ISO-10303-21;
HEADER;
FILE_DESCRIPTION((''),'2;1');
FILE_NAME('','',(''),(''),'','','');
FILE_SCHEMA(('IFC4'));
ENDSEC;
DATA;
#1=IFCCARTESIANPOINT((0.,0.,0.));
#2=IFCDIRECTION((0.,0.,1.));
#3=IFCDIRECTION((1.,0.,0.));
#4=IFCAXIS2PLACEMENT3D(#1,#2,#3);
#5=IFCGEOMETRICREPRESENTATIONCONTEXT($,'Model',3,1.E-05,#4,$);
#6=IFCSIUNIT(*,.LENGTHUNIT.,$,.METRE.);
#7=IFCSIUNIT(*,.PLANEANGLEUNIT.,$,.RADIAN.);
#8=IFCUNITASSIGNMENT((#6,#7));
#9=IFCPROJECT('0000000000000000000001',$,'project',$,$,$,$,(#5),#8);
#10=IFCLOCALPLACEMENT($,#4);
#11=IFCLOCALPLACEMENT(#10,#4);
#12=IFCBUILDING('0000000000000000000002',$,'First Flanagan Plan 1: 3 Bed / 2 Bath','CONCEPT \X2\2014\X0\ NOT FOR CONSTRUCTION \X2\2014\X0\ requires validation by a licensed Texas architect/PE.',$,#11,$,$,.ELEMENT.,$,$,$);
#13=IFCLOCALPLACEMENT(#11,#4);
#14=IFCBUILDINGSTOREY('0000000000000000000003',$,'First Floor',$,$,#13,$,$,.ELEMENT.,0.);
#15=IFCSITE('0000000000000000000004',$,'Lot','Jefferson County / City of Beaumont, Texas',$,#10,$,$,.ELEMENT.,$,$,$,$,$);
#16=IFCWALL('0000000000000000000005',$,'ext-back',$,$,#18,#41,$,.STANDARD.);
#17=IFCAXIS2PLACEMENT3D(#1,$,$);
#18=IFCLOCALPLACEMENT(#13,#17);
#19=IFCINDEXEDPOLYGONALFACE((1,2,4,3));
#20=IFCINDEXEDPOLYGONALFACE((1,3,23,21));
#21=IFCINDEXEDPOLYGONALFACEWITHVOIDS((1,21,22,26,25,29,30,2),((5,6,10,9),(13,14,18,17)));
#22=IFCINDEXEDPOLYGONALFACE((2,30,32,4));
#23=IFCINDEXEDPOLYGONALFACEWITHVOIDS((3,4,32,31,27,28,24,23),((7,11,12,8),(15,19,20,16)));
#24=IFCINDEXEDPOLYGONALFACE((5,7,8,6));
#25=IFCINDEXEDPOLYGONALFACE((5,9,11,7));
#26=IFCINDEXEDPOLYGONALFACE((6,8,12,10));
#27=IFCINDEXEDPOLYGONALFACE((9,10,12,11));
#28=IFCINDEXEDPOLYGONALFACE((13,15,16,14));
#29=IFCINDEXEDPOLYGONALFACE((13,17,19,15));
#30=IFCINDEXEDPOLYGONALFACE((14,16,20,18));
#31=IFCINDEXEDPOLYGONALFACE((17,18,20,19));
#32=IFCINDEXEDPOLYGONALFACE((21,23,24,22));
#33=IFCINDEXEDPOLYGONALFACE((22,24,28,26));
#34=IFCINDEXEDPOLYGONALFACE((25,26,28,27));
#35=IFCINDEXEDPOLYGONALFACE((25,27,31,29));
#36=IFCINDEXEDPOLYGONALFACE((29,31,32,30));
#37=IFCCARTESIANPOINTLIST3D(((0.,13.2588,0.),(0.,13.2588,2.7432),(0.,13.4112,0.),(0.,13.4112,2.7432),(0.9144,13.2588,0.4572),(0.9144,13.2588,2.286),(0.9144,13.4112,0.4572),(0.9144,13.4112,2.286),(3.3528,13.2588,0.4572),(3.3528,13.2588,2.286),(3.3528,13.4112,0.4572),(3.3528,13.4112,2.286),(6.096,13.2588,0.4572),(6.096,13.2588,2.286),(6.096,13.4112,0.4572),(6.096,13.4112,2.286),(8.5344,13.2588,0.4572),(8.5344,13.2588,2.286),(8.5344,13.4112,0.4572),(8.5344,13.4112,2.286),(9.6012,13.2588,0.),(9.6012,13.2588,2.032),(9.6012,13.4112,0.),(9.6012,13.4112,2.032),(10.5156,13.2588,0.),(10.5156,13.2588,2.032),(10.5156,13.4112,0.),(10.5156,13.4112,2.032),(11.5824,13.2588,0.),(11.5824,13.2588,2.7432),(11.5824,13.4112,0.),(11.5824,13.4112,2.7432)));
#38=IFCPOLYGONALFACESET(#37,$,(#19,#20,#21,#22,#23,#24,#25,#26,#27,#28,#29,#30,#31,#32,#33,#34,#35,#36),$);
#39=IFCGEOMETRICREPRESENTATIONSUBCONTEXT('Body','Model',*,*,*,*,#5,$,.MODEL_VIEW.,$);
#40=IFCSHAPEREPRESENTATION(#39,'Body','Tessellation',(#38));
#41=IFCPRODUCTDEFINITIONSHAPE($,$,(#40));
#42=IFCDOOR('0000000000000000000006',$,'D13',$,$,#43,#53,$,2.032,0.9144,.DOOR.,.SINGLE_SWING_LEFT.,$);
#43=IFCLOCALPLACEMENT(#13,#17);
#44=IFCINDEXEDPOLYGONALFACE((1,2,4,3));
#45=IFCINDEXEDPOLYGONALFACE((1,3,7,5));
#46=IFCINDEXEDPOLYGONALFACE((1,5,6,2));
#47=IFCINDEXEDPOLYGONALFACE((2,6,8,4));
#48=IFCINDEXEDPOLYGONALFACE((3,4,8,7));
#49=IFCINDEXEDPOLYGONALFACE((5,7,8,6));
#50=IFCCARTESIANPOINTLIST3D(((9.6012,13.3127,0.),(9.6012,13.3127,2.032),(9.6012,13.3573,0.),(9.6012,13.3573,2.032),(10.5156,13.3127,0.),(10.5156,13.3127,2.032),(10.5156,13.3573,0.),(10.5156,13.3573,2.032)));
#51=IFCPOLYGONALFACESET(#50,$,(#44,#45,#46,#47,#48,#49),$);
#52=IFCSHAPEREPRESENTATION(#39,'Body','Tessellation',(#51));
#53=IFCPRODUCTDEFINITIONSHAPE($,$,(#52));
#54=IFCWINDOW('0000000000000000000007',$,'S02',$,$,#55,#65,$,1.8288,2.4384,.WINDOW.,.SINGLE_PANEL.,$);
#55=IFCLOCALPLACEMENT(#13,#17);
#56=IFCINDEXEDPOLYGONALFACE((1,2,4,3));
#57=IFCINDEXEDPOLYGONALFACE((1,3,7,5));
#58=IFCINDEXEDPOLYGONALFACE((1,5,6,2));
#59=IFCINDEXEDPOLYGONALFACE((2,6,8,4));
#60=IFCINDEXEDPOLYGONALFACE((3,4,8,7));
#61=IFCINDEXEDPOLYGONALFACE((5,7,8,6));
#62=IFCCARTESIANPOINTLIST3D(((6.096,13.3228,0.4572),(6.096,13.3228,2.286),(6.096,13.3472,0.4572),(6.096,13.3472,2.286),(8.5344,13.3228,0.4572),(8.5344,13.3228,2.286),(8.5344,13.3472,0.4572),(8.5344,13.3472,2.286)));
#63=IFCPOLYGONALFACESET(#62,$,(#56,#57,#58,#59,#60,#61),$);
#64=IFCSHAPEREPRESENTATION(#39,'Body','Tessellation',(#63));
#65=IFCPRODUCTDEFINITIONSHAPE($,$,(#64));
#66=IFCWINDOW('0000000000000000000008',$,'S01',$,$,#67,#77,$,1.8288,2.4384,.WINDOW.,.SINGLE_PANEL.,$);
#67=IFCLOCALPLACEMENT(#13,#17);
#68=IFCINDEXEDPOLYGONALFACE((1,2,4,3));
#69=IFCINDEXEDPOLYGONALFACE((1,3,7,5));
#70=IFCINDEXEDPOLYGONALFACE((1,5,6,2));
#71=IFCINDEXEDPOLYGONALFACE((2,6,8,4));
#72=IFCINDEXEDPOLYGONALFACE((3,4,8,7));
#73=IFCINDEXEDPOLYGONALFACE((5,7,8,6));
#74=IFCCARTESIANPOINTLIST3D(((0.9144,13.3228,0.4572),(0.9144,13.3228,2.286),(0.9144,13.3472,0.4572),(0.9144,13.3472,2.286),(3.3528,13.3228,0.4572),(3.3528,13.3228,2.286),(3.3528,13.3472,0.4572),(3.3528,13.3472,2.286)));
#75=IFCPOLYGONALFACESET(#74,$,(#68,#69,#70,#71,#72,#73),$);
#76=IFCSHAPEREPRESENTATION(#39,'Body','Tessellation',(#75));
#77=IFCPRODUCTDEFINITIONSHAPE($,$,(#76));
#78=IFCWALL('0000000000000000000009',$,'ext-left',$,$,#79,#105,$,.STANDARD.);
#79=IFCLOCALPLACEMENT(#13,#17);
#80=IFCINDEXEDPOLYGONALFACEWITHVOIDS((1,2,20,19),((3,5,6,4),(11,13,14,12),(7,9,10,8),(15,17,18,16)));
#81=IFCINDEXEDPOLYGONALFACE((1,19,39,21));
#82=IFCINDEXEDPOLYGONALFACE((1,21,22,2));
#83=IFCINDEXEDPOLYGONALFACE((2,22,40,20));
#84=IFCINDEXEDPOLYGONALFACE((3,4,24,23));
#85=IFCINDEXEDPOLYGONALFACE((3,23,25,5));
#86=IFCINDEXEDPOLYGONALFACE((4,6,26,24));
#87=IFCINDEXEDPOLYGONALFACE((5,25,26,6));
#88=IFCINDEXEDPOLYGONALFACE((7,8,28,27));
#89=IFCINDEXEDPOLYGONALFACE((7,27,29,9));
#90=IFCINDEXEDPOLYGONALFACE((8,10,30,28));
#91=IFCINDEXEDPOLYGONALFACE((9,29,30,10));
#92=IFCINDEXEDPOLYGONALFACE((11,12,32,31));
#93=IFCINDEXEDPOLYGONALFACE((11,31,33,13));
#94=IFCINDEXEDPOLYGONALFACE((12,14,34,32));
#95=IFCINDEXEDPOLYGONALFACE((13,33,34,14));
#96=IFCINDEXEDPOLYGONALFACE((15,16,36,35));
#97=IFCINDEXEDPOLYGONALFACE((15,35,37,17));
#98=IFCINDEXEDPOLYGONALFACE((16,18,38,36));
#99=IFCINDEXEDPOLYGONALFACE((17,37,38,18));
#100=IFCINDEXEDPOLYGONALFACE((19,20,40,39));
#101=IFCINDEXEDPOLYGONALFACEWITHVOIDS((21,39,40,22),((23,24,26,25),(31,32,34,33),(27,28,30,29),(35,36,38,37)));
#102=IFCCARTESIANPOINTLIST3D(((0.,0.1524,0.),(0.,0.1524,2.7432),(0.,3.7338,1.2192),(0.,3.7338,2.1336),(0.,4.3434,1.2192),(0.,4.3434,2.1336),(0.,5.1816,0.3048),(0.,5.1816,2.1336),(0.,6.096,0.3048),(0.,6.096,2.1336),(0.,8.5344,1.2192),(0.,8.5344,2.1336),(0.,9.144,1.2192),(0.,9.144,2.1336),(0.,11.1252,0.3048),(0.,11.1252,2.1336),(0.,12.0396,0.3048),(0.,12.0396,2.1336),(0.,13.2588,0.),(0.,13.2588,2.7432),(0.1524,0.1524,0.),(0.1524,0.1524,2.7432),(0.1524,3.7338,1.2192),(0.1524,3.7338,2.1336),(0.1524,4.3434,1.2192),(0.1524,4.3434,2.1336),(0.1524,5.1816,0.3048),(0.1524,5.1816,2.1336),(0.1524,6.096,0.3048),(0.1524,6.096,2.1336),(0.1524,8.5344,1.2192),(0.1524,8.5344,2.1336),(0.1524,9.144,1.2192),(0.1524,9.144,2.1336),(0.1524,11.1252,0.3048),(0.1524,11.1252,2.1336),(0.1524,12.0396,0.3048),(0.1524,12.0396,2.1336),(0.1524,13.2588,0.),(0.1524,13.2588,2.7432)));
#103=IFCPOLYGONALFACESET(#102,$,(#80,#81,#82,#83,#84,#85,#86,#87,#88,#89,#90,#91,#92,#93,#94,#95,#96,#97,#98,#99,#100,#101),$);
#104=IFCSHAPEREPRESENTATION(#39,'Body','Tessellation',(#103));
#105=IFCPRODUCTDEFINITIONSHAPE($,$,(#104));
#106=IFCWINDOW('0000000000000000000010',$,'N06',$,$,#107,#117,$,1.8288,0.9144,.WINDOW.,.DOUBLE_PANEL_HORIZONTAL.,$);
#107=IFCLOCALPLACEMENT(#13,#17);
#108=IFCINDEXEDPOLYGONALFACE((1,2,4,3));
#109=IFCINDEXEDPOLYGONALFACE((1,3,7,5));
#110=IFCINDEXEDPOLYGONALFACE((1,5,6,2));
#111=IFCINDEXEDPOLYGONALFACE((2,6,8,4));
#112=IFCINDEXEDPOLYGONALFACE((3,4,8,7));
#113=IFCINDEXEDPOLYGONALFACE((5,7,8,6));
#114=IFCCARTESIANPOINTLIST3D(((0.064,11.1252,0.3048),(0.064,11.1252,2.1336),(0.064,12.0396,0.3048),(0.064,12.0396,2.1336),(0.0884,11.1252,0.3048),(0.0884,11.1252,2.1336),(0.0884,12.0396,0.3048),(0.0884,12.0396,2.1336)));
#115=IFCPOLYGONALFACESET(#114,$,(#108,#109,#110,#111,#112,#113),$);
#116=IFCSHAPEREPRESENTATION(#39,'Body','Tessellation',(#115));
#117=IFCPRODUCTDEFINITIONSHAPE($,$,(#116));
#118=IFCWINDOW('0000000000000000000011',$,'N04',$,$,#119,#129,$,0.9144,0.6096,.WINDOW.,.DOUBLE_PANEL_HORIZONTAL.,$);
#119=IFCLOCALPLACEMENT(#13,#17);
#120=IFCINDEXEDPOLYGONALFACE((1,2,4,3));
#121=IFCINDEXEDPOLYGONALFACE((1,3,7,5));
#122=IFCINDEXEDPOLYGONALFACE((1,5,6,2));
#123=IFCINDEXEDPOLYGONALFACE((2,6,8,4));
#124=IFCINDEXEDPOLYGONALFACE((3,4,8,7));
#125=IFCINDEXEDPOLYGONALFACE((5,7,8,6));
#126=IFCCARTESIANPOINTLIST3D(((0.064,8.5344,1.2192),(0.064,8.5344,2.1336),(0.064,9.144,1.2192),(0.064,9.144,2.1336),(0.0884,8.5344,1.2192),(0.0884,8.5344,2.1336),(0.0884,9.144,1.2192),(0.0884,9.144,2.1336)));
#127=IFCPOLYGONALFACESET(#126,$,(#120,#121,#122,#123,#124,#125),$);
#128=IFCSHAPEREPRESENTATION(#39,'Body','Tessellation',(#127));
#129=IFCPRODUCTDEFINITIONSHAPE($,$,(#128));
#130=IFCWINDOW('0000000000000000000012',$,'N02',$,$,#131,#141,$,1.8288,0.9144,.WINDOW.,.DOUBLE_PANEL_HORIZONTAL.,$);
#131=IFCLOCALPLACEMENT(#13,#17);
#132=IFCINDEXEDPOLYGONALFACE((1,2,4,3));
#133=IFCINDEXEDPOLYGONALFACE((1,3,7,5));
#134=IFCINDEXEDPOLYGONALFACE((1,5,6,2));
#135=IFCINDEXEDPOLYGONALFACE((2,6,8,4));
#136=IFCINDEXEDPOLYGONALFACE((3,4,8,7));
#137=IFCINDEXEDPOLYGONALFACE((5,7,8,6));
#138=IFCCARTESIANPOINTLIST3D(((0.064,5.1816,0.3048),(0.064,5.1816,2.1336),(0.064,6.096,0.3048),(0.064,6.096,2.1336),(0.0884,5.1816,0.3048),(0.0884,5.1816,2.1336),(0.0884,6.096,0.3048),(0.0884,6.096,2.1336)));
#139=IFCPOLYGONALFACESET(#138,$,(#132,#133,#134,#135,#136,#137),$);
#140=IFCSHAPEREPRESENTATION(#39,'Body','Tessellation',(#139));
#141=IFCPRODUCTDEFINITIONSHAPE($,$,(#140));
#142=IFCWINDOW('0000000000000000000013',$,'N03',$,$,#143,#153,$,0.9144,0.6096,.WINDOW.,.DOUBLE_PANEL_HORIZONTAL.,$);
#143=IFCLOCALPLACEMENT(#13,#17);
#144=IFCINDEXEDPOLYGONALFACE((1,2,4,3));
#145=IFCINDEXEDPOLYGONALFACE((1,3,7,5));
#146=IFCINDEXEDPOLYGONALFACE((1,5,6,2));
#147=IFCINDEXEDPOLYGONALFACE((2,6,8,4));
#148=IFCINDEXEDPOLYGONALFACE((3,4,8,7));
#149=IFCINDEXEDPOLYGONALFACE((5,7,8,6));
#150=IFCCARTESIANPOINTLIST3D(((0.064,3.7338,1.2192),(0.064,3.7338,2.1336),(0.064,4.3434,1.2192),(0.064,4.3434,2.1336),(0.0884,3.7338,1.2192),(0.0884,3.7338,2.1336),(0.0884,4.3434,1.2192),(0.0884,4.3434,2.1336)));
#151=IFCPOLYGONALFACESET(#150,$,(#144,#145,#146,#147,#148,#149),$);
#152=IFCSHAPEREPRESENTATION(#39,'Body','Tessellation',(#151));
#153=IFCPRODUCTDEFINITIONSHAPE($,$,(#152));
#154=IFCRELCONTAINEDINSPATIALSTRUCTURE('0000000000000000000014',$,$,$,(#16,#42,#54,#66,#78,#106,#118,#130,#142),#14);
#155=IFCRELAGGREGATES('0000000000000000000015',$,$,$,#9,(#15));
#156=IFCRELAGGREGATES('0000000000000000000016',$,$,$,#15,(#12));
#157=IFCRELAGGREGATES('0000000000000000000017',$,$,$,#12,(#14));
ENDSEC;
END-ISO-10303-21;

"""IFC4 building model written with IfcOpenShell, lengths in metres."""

from ifc_helpers import new_model, si_unit, frame, frame_2d, origin_with_axes, place, context, subcontext, project, spatial, rectangle, extrude, element, fill, save


model = new_model("IFC4")

# Units and contexts
model_context = context("Model", 3, precision=1e-05, world=origin_with_axes())
body_context = subcontext(model_context, "Body", "Model", "MODEL_VIEW")
ifc_project = project(units=[si_unit("LENGTHUNIT", "METRE"), si_unit("PLANEANGLEUNIT", "RADIAN")], contexts=[model_context])

# Site, building, storey
site_placement = place(None, origin_with_axes())
site = spatial("IfcSite", under=ifc_project, at=site_placement, Name="Lot", Description="Jefferson County / City of Beaumont, Texas", CompositionType="ELEMENT")
building_placement = place(site_placement, origin_with_axes())
building = spatial("IfcBuilding", under=site, at=building_placement, Name="First Flanagan Plan 1: 3 Bed / 2 Bath", Description="CONCEPT — NOT FOR CONSTRUCTION — requires validation by a licensed Texas architect/PE.", CompositionType="ELEMENT")
storey_placement = place(building_placement, origin_with_axes())
storey = spatial("IfcBuildingStorey", under=building, at=storey_placement, Name="First Floor", CompositionType="ELEMENT", Elevation=0.0)

# Wall, openings, door, windows
wall_1_placement = place(storey_placement, frame((11.5824, 13.335, 0.0), z_axis=(0.0, 0.0, 1.0), x_axis=(-1.0, 0.0, 0.0)))
wall_1 = element("IfcWall", 1, at=wall_1_placement, inside=storey, Name="ext-back", PredefinedType="STANDARD", context=body_context, shape_type="SweptSolid", body=[
    extrude(rectangle(XDim=11.5824, YDim=0.1524, at=frame_2d((5.7912, 0.0), x_axis=(1.0, 0.0))), origin_with_axes(), (0.0, 0.0, 1.0), 2.7432),
])
opening_1_placement = place(wall_1_placement, frame((1.0668, 0.0, 0.0), z_axis=(0.0, 0.0, 1.0), x_axis=(1.0, 0.0, 0.0)))
opening_1 = element("IfcOpeningElement", 2, at=opening_1_placement, cuts=wall_1, PredefinedType="OPENING", context=body_context, shape_type="SweptSolid", body=[
    extrude(rectangle(XDim=0.9144, YDim=0.1829, at=frame_2d((0.4572, 0.0), x_axis=(1.0, 0.0))), origin_with_axes(), (0.0, 0.0, 1.0), 2.032),
])
opening_2_placement = place(wall_1_placement, frame((3.048, 0.0, 0.4572), z_axis=(0.0, 0.0, 1.0), x_axis=(1.0, 0.0, 0.0)))
opening_2 = element("IfcOpeningElement", 3, at=opening_2_placement, cuts=wall_1, PredefinedType="OPENING", context=body_context, shape_type="SweptSolid", body=[
    extrude(rectangle(XDim=2.4384, YDim=0.1829, at=frame_2d((1.2192, 0.0), x_axis=(1.0, 0.0))), origin_with_axes(), (0.0, 0.0, 1.0), 1.8288),
])
opening_3_placement = place(wall_1_placement, frame((8.2296, 0.0, 0.4572), z_axis=(0.0, 0.0, 1.0), x_axis=(1.0, 0.0, 0.0)))
opening_3 = element("IfcOpeningElement", 4, at=opening_3_placement, cuts=wall_1, PredefinedType="OPENING", context=body_context, shape_type="SweptSolid", body=[
    extrude(rectangle(XDim=2.4384, YDim=0.1829, at=frame_2d((1.2192, 0.0), x_axis=(1.0, 0.0))), origin_with_axes(), (0.0, 0.0, 1.0), 1.8288),
])
door_1_placement = place(opening_1_placement, origin_with_axes())
door_1 = element("IfcDoor", 5, at=door_1_placement, inside=storey, Name="D13", OperationType="SINGLE_SWING_LEFT", OverallHeight=2.032, OverallWidth=0.9144, PredefinedType="DOOR", context=body_context, shape_type="SweptSolid", body=[
    extrude(rectangle(XDim=0.9144, YDim=0.0445, at=frame_2d((0.4572, 0.0), x_axis=(1.0, 0.0))), origin_with_axes(), (0.0, 0.0, 1.0), 2.032),
])
fill(opening_1, door_1)
window_1_placement = place(opening_2_placement, origin_with_axes())
window_1 = element("IfcWindow", 6, at=window_1_placement, inside=storey, Name="S02", OverallHeight=1.8288, OverallWidth=2.4384, PartitioningType="SINGLE_PANEL", PredefinedType="WINDOW", context=body_context, shape_type="SweptSolid", body=[
    extrude(rectangle(XDim=2.4384, YDim=0.0244, at=frame_2d((1.2192, 0.0), x_axis=(1.0, 0.0))), origin_with_axes(), (0.0, 0.0, 1.0), 1.8288),
])
fill(opening_2, window_1)
window_2_placement = place(opening_3_placement, origin_with_axes())
window_2 = element("IfcWindow", 7, at=window_2_placement, inside=storey, Name="S01", OverallHeight=1.8288, OverallWidth=2.4384, PartitioningType="SINGLE_PANEL", PredefinedType="WINDOW", context=body_context, shape_type="SweptSolid", body=[
    extrude(rectangle(XDim=2.4384, YDim=0.0244, at=frame_2d((1.2192, 0.0), x_axis=(1.0, 0.0))), origin_with_axes(), (0.0, 0.0, 1.0), 1.8288),
])
fill(opening_3, window_2)

# Wall, openings, windows
wall_2_placement = place(storey_placement, frame((0.0762, 13.2588, 0.0), z_axis=(0.0, 0.0, 1.0), x_axis=(0.0, -1.0, 0.0)))
wall_2 = element("IfcWall", 8, at=wall_2_placement, inside=storey, Name="ext-left", PredefinedType="STANDARD", context=body_context, shape_type="SweptSolid", body=[
    extrude(rectangle(XDim=13.1064, YDim=0.1524, at=frame_2d((6.5532, 0.0), x_axis=(1.0, 0.0))), origin_with_axes(), (0.0, 0.0, 1.0), 2.7432),
])
opening_4_placement = place(wall_2_placement, frame((1.2192, 0.0, 0.3048), z_axis=(0.0, 0.0, 1.0), x_axis=(1.0, 0.0, 0.0)))
opening_4 = element("IfcOpeningElement", 9, at=opening_4_placement, cuts=wall_2, PredefinedType="OPENING", context=body_context, shape_type="SweptSolid", body=[
    extrude(rectangle(XDim=0.9144, YDim=0.1829, at=frame_2d((0.4572, 0.0), x_axis=(1.0, 0.0))), origin_with_axes(), (0.0, 0.0, 1.0), 1.8288),
])
opening_5_placement = place(wall_2_placement, frame((4.1148, 0.0, 1.2192), z_axis=(0.0, 0.0, 1.0), x_axis=(1.0, 0.0, 0.0)))
opening_5 = element("IfcOpeningElement", 10, at=opening_5_placement, cuts=wall_2, PredefinedType="OPENING", context=body_context, shape_type="SweptSolid", body=[
    extrude(rectangle(XDim=0.6096, YDim=0.1829, at=frame_2d((0.3048, 0.0), x_axis=(1.0, 0.0))), origin_with_axes(), (0.0, 0.0, 1.0), 0.9144),
])
opening_6_placement = place(wall_2_placement, frame((7.1628, 0.0, 0.3048), z_axis=(0.0, 0.0, 1.0), x_axis=(1.0, 0.0, 0.0)))
opening_6 = element("IfcOpeningElement", 11, at=opening_6_placement, cuts=wall_2, PredefinedType="OPENING", context=body_context, shape_type="SweptSolid", body=[
    extrude(rectangle(XDim=0.9144, YDim=0.1829, at=frame_2d((0.4572, 0.0), x_axis=(1.0, 0.0))), origin_with_axes(), (0.0, 0.0, 1.0), 1.8288),
])
opening_7_placement = place(wall_2_placement, frame((8.9154, 0.0, 1.2192), z_axis=(0.0, 0.0, 1.0), x_axis=(1.0, 0.0, 0.0)))
opening_7 = element("IfcOpeningElement", 12, at=opening_7_placement, cuts=wall_2, PredefinedType="OPENING", context=body_context, shape_type="SweptSolid", body=[
    extrude(rectangle(XDim=0.6096, YDim=0.1829, at=frame_2d((0.3048, 0.0), x_axis=(1.0, 0.0))), origin_with_axes(), (0.0, 0.0, 1.0), 0.9144),
])
window_3_placement = place(opening_4_placement, origin_with_axes())
window_3 = element("IfcWindow", 13, at=window_3_placement, inside=storey, Name="N06", OverallHeight=1.8288, OverallWidth=0.9144, PartitioningType="DOUBLE_PANEL_HORIZONTAL", PredefinedType="WINDOW", context=body_context, shape_type="SweptSolid", body=[
    extrude(rectangle(XDim=0.9144, YDim=0.0244, at=frame_2d((0.4572, 0.0), x_axis=(1.0, 0.0))), origin_with_axes(), (0.0, 0.0, 1.0), 1.8288),
])
fill(opening_4, window_3)
window_4_placement = place(opening_5_placement, origin_with_axes())
window_4 = element("IfcWindow", 14, at=window_4_placement, inside=storey, Name="N04", OverallHeight=0.9144, OverallWidth=0.6096, PartitioningType="DOUBLE_PANEL_HORIZONTAL", PredefinedType="WINDOW", context=body_context, shape_type="SweptSolid", body=[
    extrude(rectangle(XDim=0.6096, YDim=0.0244, at=frame_2d((0.3048, 0.0), x_axis=(1.0, 0.0))), origin_with_axes(), (0.0, 0.0, 1.0), 0.9144),
])
fill(opening_5, window_4)
window_5_placement = place(opening_6_placement, origin_with_axes())
window_5 = element("IfcWindow", 15, at=window_5_placement, inside=storey, Name="N02", OverallHeight=1.8288, OverallWidth=0.9144, PartitioningType="DOUBLE_PANEL_HORIZONTAL", PredefinedType="WINDOW", context=body_context, shape_type="SweptSolid", body=[
    extrude(rectangle(XDim=0.9144, YDim=0.0244, at=frame_2d((0.4572, 0.0), x_axis=(1.0, 0.0))), origin_with_axes(), (0.0, 0.0, 1.0), 1.8288),
])
fill(opening_6, window_5)
window_6_placement = place(opening_7_placement, origin_with_axes())
window_6 = element("IfcWindow", 16, at=window_6_placement, inside=storey, Name="N03", OverallHeight=0.9144, OverallWidth=0.6096, PartitioningType="DOUBLE_PANEL_HORIZONTAL", PredefinedType="WINDOW", context=body_context, shape_type="SweptSolid", body=[
    extrude(rectangle(XDim=0.6096, YDim=0.0244, at=frame_2d((0.3048, 0.0), x_axis=(1.0, 0.0))), origin_with_axes(), (0.0, 0.0, 1.0), 0.9144),
])
fill(opening_7, window_6)

save(model, "model.ifc")
